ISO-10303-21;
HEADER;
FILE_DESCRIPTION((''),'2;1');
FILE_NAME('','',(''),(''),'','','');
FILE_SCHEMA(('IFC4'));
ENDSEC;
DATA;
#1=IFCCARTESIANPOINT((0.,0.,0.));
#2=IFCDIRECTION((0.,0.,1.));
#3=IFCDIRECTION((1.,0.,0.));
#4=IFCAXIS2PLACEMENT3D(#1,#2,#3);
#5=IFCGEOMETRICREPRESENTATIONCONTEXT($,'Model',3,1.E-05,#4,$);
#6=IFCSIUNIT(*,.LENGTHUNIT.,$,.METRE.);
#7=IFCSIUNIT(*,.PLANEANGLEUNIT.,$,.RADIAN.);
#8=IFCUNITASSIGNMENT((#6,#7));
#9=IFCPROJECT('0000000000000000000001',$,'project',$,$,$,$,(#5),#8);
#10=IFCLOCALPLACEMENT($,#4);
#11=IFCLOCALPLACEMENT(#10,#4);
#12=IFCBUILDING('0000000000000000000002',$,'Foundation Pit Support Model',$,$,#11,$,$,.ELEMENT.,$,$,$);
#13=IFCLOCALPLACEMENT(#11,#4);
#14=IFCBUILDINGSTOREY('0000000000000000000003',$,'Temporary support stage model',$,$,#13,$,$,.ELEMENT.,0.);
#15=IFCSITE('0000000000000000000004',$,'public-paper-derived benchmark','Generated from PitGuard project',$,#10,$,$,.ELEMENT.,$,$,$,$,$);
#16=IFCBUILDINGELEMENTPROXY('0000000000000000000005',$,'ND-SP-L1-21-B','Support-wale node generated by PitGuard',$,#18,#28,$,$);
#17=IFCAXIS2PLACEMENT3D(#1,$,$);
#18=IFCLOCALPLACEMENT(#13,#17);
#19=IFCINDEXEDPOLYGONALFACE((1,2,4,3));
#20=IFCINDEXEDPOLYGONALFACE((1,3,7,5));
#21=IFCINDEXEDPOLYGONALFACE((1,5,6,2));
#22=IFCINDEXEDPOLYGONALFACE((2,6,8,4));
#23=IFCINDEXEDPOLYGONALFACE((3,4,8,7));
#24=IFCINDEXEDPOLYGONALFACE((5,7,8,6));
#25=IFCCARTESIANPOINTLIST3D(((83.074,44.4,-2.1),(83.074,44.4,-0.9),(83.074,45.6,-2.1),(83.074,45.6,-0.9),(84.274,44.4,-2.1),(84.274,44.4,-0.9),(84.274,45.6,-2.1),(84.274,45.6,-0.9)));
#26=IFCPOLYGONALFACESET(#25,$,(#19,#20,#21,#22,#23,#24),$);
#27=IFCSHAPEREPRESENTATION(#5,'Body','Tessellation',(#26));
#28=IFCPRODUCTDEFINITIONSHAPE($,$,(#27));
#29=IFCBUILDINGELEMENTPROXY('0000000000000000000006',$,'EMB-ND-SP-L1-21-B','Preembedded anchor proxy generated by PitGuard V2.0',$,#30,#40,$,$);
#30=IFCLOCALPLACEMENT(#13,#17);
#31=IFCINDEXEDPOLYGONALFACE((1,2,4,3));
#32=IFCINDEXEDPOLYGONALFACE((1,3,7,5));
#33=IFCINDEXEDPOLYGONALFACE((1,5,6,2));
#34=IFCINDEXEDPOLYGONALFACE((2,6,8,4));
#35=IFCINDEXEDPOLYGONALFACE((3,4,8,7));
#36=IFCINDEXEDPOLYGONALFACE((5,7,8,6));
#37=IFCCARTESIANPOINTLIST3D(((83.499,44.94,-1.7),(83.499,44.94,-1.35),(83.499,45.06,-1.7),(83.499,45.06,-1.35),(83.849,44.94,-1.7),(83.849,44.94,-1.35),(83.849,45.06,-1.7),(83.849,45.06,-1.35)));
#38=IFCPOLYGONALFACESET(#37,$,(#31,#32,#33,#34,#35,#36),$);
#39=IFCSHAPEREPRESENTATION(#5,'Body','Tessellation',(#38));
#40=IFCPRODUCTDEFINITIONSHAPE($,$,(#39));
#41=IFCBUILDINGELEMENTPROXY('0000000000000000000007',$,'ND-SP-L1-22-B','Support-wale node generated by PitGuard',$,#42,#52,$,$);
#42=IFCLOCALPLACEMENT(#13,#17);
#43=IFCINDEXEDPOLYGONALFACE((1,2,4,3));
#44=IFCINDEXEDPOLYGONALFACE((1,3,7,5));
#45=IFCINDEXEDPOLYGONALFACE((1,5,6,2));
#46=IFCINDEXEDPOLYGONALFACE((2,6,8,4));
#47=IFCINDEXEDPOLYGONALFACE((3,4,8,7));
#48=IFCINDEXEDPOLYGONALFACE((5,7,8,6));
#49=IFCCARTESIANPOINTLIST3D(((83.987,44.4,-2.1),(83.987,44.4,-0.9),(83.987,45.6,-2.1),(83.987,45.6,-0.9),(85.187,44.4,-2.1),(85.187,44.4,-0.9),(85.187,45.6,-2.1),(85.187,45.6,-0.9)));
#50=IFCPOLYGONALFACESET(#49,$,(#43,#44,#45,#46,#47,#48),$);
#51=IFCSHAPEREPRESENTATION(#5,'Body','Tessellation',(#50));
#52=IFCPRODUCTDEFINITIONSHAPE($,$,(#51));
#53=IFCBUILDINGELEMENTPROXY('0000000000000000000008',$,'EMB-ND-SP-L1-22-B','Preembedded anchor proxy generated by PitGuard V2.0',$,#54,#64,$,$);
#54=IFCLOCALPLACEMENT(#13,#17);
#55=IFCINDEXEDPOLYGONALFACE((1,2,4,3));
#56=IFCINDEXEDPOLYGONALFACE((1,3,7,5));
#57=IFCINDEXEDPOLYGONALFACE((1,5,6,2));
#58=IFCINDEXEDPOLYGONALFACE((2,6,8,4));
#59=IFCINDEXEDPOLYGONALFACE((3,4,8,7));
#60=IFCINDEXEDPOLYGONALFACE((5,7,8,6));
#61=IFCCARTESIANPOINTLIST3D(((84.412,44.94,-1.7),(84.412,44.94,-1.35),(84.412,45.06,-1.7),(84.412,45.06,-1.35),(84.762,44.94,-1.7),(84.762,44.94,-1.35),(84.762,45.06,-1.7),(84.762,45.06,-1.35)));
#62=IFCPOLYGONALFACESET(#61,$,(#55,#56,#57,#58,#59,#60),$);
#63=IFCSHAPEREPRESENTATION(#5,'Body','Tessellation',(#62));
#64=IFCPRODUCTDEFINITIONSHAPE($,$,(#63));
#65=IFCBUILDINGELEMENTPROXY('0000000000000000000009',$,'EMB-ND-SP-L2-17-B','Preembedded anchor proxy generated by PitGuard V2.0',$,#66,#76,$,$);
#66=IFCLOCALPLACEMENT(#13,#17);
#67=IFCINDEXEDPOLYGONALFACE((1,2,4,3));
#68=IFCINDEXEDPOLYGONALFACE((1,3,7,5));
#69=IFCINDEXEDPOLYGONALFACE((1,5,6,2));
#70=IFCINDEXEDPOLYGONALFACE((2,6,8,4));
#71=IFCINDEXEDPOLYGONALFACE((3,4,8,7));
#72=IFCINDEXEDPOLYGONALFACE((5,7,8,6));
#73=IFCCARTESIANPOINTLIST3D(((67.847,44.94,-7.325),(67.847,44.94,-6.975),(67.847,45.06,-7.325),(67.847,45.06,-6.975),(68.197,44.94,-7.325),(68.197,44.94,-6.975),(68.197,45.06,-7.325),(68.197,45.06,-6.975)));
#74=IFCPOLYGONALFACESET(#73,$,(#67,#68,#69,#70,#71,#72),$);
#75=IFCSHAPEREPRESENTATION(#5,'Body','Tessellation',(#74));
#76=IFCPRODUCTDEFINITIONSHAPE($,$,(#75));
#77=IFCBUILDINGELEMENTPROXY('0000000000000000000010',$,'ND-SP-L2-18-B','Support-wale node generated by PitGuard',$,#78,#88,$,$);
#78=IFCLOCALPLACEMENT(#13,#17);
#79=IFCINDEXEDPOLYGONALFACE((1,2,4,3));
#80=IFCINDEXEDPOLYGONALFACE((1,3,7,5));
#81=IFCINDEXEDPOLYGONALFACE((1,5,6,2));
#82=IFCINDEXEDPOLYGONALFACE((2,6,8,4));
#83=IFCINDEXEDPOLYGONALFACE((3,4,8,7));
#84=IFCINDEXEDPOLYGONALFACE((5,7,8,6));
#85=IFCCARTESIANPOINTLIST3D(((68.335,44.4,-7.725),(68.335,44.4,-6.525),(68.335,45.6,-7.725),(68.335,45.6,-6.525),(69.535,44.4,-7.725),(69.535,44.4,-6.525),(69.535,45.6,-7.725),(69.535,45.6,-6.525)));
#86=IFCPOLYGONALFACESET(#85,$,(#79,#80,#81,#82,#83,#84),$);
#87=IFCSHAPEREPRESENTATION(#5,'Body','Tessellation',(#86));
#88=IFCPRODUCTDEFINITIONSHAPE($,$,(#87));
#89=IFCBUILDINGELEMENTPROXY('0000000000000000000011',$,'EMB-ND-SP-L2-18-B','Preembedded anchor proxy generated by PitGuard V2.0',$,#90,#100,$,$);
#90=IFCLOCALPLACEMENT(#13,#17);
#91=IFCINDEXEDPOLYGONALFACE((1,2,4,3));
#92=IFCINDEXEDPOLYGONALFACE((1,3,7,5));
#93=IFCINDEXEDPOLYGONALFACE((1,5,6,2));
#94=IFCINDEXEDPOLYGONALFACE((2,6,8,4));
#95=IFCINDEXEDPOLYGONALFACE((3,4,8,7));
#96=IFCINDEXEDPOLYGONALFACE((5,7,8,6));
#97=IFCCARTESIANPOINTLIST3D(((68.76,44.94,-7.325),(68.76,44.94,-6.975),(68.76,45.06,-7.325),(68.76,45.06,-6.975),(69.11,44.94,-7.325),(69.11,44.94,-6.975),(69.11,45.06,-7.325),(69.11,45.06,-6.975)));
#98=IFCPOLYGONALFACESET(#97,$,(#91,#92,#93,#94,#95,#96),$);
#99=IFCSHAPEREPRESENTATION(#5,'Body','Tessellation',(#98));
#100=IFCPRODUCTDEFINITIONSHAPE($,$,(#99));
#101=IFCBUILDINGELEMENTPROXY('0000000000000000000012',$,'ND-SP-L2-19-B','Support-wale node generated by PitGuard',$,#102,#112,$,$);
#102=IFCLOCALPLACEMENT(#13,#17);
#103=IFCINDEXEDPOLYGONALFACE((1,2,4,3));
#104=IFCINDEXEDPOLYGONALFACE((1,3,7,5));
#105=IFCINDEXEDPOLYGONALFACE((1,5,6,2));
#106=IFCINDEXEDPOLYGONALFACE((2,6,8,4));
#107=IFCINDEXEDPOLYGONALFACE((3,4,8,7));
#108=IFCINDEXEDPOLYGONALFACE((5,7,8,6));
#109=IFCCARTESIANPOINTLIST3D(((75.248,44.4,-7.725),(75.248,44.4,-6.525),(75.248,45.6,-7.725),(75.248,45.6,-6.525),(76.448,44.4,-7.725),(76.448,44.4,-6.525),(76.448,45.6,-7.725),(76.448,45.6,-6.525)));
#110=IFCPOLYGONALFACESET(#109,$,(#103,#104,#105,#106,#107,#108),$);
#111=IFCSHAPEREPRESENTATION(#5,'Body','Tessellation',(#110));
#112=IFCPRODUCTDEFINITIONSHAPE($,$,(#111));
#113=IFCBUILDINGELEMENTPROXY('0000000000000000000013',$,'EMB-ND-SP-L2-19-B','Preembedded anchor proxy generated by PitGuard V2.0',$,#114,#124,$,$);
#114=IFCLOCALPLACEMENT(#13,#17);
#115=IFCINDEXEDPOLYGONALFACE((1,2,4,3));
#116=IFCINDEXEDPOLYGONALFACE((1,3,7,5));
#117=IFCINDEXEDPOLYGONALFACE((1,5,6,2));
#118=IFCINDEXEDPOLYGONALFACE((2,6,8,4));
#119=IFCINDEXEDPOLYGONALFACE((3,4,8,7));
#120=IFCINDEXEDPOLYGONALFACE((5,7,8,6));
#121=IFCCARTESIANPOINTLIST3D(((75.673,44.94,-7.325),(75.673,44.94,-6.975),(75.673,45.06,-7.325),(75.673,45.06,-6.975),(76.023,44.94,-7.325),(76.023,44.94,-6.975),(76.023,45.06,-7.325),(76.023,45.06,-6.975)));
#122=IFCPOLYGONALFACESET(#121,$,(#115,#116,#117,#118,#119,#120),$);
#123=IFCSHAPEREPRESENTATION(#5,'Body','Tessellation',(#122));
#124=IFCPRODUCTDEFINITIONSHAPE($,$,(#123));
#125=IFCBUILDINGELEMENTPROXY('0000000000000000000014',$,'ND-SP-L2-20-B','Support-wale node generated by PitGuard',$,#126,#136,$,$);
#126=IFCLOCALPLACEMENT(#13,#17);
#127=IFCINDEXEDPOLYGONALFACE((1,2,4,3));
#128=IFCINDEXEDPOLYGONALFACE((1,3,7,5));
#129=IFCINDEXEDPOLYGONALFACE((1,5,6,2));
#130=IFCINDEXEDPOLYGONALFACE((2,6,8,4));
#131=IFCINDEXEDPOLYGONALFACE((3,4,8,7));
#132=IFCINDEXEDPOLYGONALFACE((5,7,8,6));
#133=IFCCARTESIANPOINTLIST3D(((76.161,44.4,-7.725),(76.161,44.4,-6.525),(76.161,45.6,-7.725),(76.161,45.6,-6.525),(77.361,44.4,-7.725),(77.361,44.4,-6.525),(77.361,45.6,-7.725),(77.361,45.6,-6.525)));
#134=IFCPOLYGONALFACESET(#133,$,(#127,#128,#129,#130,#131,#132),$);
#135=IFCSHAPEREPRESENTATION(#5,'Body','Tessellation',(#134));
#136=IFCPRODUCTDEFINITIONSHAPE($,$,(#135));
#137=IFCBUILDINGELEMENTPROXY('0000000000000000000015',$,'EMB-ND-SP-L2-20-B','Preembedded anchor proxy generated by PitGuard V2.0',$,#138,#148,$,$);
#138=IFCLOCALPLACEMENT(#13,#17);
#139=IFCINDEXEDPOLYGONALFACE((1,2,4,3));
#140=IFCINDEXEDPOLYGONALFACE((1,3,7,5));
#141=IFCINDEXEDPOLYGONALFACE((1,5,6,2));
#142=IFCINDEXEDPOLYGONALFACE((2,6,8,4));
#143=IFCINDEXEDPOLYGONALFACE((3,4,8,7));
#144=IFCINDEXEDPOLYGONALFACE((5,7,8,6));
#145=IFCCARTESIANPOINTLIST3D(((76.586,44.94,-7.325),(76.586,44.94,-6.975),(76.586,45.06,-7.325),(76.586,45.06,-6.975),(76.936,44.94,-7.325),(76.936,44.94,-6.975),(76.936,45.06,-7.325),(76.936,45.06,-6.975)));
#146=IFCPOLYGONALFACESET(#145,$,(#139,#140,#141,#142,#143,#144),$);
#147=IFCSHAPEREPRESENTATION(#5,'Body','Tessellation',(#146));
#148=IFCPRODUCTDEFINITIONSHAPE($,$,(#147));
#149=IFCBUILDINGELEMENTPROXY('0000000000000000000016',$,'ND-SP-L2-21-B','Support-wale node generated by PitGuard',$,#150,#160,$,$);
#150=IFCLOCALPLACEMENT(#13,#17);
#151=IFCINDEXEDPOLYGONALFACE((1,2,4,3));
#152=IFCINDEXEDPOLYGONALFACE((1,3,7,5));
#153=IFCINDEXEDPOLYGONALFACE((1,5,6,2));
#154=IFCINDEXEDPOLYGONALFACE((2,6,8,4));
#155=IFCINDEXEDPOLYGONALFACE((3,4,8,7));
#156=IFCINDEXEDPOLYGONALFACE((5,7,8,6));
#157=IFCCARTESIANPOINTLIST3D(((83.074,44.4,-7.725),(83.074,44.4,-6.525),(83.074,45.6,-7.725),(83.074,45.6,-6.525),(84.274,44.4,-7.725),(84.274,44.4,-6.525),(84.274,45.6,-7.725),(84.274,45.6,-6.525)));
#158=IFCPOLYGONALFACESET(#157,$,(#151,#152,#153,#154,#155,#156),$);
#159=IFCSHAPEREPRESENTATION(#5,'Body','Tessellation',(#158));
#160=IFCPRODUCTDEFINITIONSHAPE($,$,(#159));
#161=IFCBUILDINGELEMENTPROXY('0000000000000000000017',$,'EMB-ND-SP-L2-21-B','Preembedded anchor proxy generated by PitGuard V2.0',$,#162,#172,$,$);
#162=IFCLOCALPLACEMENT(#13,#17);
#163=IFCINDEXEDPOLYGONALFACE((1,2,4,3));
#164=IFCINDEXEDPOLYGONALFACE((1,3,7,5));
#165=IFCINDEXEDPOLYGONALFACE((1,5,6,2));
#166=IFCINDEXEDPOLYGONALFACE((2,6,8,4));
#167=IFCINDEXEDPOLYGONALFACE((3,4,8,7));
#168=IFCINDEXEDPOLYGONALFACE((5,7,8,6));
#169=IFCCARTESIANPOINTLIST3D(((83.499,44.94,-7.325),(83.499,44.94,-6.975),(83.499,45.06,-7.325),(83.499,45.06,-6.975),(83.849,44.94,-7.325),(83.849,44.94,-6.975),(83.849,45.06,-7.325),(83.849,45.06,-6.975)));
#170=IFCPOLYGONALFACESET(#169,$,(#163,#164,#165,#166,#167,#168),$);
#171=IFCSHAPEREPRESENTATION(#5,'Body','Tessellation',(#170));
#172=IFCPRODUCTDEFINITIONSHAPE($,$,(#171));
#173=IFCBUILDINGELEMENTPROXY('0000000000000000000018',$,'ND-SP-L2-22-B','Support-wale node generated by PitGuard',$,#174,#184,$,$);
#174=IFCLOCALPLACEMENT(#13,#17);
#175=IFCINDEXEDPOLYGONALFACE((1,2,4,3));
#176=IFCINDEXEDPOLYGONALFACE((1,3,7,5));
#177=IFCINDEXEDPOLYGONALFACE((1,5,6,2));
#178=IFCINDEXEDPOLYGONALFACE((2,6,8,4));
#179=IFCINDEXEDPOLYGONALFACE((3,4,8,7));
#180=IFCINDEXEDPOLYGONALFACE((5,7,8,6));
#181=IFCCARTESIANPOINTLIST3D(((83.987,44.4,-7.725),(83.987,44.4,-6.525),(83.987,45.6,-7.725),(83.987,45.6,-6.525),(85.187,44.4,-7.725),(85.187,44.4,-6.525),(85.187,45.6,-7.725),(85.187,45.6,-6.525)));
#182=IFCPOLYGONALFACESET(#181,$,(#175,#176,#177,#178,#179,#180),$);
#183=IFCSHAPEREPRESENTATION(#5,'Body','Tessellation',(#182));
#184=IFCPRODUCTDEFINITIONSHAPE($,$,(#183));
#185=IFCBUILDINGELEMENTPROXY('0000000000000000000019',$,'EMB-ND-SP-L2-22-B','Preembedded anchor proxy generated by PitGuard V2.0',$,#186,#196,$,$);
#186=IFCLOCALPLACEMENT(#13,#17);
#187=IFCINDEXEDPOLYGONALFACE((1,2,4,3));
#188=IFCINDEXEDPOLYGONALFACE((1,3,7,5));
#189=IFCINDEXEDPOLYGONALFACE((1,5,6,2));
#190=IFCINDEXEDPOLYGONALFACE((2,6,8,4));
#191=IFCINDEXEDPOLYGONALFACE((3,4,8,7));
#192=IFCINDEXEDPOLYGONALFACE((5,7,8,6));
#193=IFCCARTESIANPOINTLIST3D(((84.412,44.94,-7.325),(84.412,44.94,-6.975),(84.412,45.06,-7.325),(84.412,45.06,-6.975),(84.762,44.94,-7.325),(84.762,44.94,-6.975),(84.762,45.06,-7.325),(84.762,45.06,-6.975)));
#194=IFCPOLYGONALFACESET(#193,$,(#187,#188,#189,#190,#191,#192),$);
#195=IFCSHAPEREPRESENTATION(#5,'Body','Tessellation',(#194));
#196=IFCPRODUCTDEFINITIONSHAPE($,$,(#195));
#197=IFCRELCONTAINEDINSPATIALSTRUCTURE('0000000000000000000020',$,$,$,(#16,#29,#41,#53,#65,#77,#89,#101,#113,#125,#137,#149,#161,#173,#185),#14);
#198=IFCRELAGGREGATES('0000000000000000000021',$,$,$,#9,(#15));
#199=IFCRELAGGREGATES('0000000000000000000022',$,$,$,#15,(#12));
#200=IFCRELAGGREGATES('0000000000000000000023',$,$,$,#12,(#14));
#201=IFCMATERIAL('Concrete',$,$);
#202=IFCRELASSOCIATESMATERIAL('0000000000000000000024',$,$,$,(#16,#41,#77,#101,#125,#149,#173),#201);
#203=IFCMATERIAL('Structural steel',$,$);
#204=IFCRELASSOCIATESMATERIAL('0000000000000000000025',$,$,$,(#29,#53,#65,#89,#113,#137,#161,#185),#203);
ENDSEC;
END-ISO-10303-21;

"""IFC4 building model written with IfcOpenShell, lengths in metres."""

from ifc_helpers import new_model, si_unit, frame, origin_with_axes, origin_2d, place, context, project, spatial, rectangle, extrude, material, element, save


model = new_model("IFC4")

# Units and contexts
model_context = context("Model", 3, precision=1e-05, world=origin_with_axes())
ifc_project = project(units=[si_unit("LENGTHUNIT", "METRE"), si_unit("PLANEANGLEUNIT", "RADIAN")], contexts=[model_context])

# Site, building, storey
site_placement = place(None, origin_with_axes())
site = spatial("IfcSite", under=ifc_project, at=site_placement, Name="public-paper-derived benchmark", Description="Generated from PitGuard project", CompositionType="ELEMENT")
building_placement = place(site_placement, origin_with_axes())
building = spatial("IfcBuilding", under=site, at=building_placement, Name="Foundation Pit Support Model", CompositionType="ELEMENT")
storey_placement = place(building_placement, origin_with_axes())
storey = spatial("IfcBuildingStorey", under=building, at=storey_placement, Name="Temporary support stage model", CompositionType="ELEMENT", Elevation=0.0)

# Shared definitions
ifc_material_1 = material(Name="Structural steel")

# Building element proxies
ifc_material_2 = material(Name="Concrete")
proxy_1_placement = place(storey_placement, frame((83.674, 45.0, -2.1), z_axis=(0.0, 0.0, 1.0), x_axis=(1.0, 0.0, 0.0)))
element("IfcBuildingElementProxy", 1, at=proxy_1_placement, inside=storey, material=ifc_material_2, Name="ND-SP-L1-21-B", Description="Support-wale node generated by PitGuard", context=model_context, shape_type="SweptSolid", body=[
    extrude(rectangle(XDim=1.2, YDim=1.2, at=origin_2d()), origin_with_axes(), (0.0, 0.0, 1.0), 1.2),
])
proxy_2_placement = place(storey_placement, frame((83.674, 45.0, -1.7), z_axis=(0.0, 0.0, 1.0), x_axis=(1.0, 0.0, 0.0)))
element("IfcBuildingElementProxy", 2, at=proxy_2_placement, inside=storey, material=ifc_material_1, Name="EMB-ND-SP-L1-21-B", Description="Preembedded anchor proxy generated by PitGuard V2.0", context=model_context, shape_type="SweptSolid", body=[
    extrude(rectangle(XDim=0.35, YDim=0.12, at=origin_2d()), origin_with_axes(), (0.0, 0.0, 1.0), 0.35),
])
proxy_3_placement = place(storey_placement, frame((84.587, 45.0, -2.1), z_axis=(0.0, 0.0, 1.0), x_axis=(1.0, 0.0, 0.0)))
element("IfcBuildingElementProxy", 3, at=proxy_3_placement, inside=storey, material=ifc_material_2, Name="ND-SP-L1-22-B", Description="Support-wale node generated by PitGuard", context=model_context, shape_type="SweptSolid", body=[
    extrude(rectangle(XDim=1.2, YDim=1.2, at=origin_2d()), origin_with_axes(), (0.0, 0.0, 1.0), 1.2),
])
for number, where, z_axis, x_axis, name in (
    (4, (84.587, 45.0, -1.7), (0.0, 0.0, 1.0), (1.0, 0.0, 0.0), "EMB-ND-SP-L1-22-B"),
    (5, (68.022, 45.0, -7.325), (0.0, 0.0, 1.0), (1.0, 0.0, 0.0), "EMB-ND-SP-L2-17-B"),
):
    element("IfcBuildingElementProxy", number, at=place(storey_placement, frame(where, z_axis=z_axis, x_axis=x_axis)), inside=storey, material=ifc_material_1, Name=name, Description="Preembedded anchor proxy generated by PitGuard V2.0", context=model_context, shape_type="SweptSolid", body=[
        extrude(rectangle(XDim=0.35, YDim=0.12, at=origin_2d()), origin_with_axes(), (0.0, 0.0, 1.0), 0.35),
    ])
proxy_4_placement = place(storey_placement, frame((68.935, 45.0, -7.725), z_axis=(0.0, 0.0, 1.0), x_axis=(1.0, 0.0, 0.0)))
element("IfcBuildingElementProxy", 6, at=proxy_4_placement, inside=storey, material=ifc_material_2, Name="ND-SP-L2-18-B", Description="Support-wale node generated by PitGuard", context=model_context, shape_type="SweptSolid", body=[
    extrude(rectangle(XDim=1.2, YDim=1.2, at=origin_2d()), origin_with_axes(), (0.0, 0.0, 1.0), 1.2),
])
proxy_5_placement = place(storey_placement, frame((68.935, 45.0, -7.325), z_axis=(0.0, 0.0, 1.0), x_axis=(1.0, 0.0, 0.0)))
element("IfcBuildingElementProxy", 7, at=proxy_5_placement, inside=storey, material=ifc_material_1, Name="EMB-ND-SP-L2-18-B", Description="Preembedded anchor proxy generated by PitGuard V2.0", context=model_context, shape_type="SweptSolid", body=[
    extrude(rectangle(XDim=0.35, YDim=0.12, at=origin_2d()), origin_with_axes(), (0.0, 0.0, 1.0), 0.35),
])
proxy_6_placement = place(storey_placement, frame((75.848, 45.0, -7.725), z_axis=(0.0, 0.0, 1.0), x_axis=(1.0, 0.0, 0.0)))
element("IfcBuildingElementProxy", 8, at=proxy_6_placement, inside=storey, material=ifc_material_2, Name="ND-SP-L2-19-B", Description="Support-wale node generated by PitGuard", context=model_context, shape_type="SweptSolid", body=[
    extrude(rectangle(XDim=1.2, YDim=1.2, at=origin_2d()), origin_with_axes(), (0.0, 0.0, 1.0), 1.2),
])
proxy_7_placement = place(storey_placement, frame((75.848, 45.0, -7.325), z_axis=(0.0, 0.0, 1.0), x_axis=(1.0, 0.0, 0.0)))
element("IfcBuildingElementProxy", 9, at=proxy_7_placement, inside=storey, material=ifc_material_1, Name="EMB-ND-SP-L2-19-B", Description="Preembedded anchor proxy generated by PitGuard V2.0", context=model_context, shape_type="SweptSolid", body=[
    extrude(rectangle(XDim=0.35, YDim=0.12, at=origin_2d()), origin_with_axes(), (0.0, 0.0, 1.0), 0.35),
])
proxy_8_placement = place(storey_placement, frame((76.761, 45.0, -7.725), z_axis=(0.0, 0.0, 1.0), x_axis=(1.0, 0.0, 0.0)))
element("IfcBuildingElementProxy", 10, at=proxy_8_placement, inside=storey, material=ifc_material_2, Name="ND-SP-L2-20-B", Description="Support-wale node generated by PitGuard", context=model_context, shape_type="SweptSolid", body=[
    extrude(rectangle(XDim=1.2, YDim=1.2, at=origin_2d()), origin_with_axes(), (0.0, 0.0, 1.0), 1.2),
])
proxy_9_placement = place(storey_placement, frame((76.761, 45.0, -7.325), z_axis=(0.0, 0.0, 1.0), x_axis=(1.0, 0.0, 0.0)))
element("IfcBuildingElementProxy", 11, at=proxy_9_placement, inside=storey, material=ifc_material_1, Name="EMB-ND-SP-L2-20-B", Description="Preembedded anchor proxy generated by PitGuard V2.0", context=model_context, shape_type="SweptSolid", body=[
    extrude(rectangle(XDim=0.35, YDim=0.12, at=origin_2d()), origin_with_axes(), (0.0, 0.0, 1.0), 0.35),
])
proxy_10_placement = place(storey_placement, frame((83.674, 45.0, -7.725), z_axis=(0.0, 0.0, 1.0), x_axis=(1.0, 0.0, 0.0)))
element("IfcBuildingElementProxy", 12, at=proxy_10_placement, inside=storey, material=ifc_material_2, Name="ND-SP-L2-21-B", Description="Support-wale node generated by PitGuard", context=model_context, shape_type="SweptSolid", body=[
    extrude(rectangle(XDim=1.2, YDim=1.2, at=origin_2d()), origin_with_axes(), (0.0, 0.0, 1.0), 1.2),
])
proxy_11_placement = place(storey_placement, frame((83.674, 45.0, -7.325), z_axis=(0.0, 0.0, 1.0), x_axis=(1.0, 0.0, 0.0)))
element("IfcBuildingElementProxy", 13, at=proxy_11_placement, inside=storey, material=ifc_material_1, Name="EMB-ND-SP-L2-21-B", Description="Preembedded anchor proxy generated by PitGuard V2.0", context=model_context, shape_type="SweptSolid", body=[
    extrude(rectangle(XDim=0.35, YDim=0.12, at=origin_2d()), origin_with_axes(), (0.0, 0.0, 1.0), 0.35),
])
proxy_12_placement = place(storey_placement, frame((84.587, 45.0, -7.725), z_axis=(0.0, 0.0, 1.0), x_axis=(1.0, 0.0, 0.0)))
element("IfcBuildingElementProxy", 14, at=proxy_12_placement, inside=storey, material=ifc_material_2, Name="ND-SP-L2-22-B", Description="Support-wale node generated by PitGuard", context=model_context, shape_type="SweptSolid", body=[
    extrude(rectangle(XDim=1.2, YDim=1.2, at=origin_2d()), origin_with_axes(), (0.0, 0.0, 1.0), 1.2),
])
proxy_13_placement = place(storey_placement, frame((84.587, 45.0, -7.325), z_axis=(0.0, 0.0, 1.0), x_axis=(1.0, 0.0, 0.0)))
element("IfcBuildingElementProxy", 15, at=proxy_13_placement, inside=storey, material=ifc_material_1, Name="EMB-ND-SP-L2-22-B", Description="Preembedded anchor proxy generated by PitGuard V2.0", context=model_context, shape_type="SweptSolid", body=[
    extrude(rectangle(XDim=0.35, YDim=0.12, at=origin_2d()), origin_with_axes(), (0.0, 0.0, 1.0), 0.35),
])

save(model, "model.ifc")
